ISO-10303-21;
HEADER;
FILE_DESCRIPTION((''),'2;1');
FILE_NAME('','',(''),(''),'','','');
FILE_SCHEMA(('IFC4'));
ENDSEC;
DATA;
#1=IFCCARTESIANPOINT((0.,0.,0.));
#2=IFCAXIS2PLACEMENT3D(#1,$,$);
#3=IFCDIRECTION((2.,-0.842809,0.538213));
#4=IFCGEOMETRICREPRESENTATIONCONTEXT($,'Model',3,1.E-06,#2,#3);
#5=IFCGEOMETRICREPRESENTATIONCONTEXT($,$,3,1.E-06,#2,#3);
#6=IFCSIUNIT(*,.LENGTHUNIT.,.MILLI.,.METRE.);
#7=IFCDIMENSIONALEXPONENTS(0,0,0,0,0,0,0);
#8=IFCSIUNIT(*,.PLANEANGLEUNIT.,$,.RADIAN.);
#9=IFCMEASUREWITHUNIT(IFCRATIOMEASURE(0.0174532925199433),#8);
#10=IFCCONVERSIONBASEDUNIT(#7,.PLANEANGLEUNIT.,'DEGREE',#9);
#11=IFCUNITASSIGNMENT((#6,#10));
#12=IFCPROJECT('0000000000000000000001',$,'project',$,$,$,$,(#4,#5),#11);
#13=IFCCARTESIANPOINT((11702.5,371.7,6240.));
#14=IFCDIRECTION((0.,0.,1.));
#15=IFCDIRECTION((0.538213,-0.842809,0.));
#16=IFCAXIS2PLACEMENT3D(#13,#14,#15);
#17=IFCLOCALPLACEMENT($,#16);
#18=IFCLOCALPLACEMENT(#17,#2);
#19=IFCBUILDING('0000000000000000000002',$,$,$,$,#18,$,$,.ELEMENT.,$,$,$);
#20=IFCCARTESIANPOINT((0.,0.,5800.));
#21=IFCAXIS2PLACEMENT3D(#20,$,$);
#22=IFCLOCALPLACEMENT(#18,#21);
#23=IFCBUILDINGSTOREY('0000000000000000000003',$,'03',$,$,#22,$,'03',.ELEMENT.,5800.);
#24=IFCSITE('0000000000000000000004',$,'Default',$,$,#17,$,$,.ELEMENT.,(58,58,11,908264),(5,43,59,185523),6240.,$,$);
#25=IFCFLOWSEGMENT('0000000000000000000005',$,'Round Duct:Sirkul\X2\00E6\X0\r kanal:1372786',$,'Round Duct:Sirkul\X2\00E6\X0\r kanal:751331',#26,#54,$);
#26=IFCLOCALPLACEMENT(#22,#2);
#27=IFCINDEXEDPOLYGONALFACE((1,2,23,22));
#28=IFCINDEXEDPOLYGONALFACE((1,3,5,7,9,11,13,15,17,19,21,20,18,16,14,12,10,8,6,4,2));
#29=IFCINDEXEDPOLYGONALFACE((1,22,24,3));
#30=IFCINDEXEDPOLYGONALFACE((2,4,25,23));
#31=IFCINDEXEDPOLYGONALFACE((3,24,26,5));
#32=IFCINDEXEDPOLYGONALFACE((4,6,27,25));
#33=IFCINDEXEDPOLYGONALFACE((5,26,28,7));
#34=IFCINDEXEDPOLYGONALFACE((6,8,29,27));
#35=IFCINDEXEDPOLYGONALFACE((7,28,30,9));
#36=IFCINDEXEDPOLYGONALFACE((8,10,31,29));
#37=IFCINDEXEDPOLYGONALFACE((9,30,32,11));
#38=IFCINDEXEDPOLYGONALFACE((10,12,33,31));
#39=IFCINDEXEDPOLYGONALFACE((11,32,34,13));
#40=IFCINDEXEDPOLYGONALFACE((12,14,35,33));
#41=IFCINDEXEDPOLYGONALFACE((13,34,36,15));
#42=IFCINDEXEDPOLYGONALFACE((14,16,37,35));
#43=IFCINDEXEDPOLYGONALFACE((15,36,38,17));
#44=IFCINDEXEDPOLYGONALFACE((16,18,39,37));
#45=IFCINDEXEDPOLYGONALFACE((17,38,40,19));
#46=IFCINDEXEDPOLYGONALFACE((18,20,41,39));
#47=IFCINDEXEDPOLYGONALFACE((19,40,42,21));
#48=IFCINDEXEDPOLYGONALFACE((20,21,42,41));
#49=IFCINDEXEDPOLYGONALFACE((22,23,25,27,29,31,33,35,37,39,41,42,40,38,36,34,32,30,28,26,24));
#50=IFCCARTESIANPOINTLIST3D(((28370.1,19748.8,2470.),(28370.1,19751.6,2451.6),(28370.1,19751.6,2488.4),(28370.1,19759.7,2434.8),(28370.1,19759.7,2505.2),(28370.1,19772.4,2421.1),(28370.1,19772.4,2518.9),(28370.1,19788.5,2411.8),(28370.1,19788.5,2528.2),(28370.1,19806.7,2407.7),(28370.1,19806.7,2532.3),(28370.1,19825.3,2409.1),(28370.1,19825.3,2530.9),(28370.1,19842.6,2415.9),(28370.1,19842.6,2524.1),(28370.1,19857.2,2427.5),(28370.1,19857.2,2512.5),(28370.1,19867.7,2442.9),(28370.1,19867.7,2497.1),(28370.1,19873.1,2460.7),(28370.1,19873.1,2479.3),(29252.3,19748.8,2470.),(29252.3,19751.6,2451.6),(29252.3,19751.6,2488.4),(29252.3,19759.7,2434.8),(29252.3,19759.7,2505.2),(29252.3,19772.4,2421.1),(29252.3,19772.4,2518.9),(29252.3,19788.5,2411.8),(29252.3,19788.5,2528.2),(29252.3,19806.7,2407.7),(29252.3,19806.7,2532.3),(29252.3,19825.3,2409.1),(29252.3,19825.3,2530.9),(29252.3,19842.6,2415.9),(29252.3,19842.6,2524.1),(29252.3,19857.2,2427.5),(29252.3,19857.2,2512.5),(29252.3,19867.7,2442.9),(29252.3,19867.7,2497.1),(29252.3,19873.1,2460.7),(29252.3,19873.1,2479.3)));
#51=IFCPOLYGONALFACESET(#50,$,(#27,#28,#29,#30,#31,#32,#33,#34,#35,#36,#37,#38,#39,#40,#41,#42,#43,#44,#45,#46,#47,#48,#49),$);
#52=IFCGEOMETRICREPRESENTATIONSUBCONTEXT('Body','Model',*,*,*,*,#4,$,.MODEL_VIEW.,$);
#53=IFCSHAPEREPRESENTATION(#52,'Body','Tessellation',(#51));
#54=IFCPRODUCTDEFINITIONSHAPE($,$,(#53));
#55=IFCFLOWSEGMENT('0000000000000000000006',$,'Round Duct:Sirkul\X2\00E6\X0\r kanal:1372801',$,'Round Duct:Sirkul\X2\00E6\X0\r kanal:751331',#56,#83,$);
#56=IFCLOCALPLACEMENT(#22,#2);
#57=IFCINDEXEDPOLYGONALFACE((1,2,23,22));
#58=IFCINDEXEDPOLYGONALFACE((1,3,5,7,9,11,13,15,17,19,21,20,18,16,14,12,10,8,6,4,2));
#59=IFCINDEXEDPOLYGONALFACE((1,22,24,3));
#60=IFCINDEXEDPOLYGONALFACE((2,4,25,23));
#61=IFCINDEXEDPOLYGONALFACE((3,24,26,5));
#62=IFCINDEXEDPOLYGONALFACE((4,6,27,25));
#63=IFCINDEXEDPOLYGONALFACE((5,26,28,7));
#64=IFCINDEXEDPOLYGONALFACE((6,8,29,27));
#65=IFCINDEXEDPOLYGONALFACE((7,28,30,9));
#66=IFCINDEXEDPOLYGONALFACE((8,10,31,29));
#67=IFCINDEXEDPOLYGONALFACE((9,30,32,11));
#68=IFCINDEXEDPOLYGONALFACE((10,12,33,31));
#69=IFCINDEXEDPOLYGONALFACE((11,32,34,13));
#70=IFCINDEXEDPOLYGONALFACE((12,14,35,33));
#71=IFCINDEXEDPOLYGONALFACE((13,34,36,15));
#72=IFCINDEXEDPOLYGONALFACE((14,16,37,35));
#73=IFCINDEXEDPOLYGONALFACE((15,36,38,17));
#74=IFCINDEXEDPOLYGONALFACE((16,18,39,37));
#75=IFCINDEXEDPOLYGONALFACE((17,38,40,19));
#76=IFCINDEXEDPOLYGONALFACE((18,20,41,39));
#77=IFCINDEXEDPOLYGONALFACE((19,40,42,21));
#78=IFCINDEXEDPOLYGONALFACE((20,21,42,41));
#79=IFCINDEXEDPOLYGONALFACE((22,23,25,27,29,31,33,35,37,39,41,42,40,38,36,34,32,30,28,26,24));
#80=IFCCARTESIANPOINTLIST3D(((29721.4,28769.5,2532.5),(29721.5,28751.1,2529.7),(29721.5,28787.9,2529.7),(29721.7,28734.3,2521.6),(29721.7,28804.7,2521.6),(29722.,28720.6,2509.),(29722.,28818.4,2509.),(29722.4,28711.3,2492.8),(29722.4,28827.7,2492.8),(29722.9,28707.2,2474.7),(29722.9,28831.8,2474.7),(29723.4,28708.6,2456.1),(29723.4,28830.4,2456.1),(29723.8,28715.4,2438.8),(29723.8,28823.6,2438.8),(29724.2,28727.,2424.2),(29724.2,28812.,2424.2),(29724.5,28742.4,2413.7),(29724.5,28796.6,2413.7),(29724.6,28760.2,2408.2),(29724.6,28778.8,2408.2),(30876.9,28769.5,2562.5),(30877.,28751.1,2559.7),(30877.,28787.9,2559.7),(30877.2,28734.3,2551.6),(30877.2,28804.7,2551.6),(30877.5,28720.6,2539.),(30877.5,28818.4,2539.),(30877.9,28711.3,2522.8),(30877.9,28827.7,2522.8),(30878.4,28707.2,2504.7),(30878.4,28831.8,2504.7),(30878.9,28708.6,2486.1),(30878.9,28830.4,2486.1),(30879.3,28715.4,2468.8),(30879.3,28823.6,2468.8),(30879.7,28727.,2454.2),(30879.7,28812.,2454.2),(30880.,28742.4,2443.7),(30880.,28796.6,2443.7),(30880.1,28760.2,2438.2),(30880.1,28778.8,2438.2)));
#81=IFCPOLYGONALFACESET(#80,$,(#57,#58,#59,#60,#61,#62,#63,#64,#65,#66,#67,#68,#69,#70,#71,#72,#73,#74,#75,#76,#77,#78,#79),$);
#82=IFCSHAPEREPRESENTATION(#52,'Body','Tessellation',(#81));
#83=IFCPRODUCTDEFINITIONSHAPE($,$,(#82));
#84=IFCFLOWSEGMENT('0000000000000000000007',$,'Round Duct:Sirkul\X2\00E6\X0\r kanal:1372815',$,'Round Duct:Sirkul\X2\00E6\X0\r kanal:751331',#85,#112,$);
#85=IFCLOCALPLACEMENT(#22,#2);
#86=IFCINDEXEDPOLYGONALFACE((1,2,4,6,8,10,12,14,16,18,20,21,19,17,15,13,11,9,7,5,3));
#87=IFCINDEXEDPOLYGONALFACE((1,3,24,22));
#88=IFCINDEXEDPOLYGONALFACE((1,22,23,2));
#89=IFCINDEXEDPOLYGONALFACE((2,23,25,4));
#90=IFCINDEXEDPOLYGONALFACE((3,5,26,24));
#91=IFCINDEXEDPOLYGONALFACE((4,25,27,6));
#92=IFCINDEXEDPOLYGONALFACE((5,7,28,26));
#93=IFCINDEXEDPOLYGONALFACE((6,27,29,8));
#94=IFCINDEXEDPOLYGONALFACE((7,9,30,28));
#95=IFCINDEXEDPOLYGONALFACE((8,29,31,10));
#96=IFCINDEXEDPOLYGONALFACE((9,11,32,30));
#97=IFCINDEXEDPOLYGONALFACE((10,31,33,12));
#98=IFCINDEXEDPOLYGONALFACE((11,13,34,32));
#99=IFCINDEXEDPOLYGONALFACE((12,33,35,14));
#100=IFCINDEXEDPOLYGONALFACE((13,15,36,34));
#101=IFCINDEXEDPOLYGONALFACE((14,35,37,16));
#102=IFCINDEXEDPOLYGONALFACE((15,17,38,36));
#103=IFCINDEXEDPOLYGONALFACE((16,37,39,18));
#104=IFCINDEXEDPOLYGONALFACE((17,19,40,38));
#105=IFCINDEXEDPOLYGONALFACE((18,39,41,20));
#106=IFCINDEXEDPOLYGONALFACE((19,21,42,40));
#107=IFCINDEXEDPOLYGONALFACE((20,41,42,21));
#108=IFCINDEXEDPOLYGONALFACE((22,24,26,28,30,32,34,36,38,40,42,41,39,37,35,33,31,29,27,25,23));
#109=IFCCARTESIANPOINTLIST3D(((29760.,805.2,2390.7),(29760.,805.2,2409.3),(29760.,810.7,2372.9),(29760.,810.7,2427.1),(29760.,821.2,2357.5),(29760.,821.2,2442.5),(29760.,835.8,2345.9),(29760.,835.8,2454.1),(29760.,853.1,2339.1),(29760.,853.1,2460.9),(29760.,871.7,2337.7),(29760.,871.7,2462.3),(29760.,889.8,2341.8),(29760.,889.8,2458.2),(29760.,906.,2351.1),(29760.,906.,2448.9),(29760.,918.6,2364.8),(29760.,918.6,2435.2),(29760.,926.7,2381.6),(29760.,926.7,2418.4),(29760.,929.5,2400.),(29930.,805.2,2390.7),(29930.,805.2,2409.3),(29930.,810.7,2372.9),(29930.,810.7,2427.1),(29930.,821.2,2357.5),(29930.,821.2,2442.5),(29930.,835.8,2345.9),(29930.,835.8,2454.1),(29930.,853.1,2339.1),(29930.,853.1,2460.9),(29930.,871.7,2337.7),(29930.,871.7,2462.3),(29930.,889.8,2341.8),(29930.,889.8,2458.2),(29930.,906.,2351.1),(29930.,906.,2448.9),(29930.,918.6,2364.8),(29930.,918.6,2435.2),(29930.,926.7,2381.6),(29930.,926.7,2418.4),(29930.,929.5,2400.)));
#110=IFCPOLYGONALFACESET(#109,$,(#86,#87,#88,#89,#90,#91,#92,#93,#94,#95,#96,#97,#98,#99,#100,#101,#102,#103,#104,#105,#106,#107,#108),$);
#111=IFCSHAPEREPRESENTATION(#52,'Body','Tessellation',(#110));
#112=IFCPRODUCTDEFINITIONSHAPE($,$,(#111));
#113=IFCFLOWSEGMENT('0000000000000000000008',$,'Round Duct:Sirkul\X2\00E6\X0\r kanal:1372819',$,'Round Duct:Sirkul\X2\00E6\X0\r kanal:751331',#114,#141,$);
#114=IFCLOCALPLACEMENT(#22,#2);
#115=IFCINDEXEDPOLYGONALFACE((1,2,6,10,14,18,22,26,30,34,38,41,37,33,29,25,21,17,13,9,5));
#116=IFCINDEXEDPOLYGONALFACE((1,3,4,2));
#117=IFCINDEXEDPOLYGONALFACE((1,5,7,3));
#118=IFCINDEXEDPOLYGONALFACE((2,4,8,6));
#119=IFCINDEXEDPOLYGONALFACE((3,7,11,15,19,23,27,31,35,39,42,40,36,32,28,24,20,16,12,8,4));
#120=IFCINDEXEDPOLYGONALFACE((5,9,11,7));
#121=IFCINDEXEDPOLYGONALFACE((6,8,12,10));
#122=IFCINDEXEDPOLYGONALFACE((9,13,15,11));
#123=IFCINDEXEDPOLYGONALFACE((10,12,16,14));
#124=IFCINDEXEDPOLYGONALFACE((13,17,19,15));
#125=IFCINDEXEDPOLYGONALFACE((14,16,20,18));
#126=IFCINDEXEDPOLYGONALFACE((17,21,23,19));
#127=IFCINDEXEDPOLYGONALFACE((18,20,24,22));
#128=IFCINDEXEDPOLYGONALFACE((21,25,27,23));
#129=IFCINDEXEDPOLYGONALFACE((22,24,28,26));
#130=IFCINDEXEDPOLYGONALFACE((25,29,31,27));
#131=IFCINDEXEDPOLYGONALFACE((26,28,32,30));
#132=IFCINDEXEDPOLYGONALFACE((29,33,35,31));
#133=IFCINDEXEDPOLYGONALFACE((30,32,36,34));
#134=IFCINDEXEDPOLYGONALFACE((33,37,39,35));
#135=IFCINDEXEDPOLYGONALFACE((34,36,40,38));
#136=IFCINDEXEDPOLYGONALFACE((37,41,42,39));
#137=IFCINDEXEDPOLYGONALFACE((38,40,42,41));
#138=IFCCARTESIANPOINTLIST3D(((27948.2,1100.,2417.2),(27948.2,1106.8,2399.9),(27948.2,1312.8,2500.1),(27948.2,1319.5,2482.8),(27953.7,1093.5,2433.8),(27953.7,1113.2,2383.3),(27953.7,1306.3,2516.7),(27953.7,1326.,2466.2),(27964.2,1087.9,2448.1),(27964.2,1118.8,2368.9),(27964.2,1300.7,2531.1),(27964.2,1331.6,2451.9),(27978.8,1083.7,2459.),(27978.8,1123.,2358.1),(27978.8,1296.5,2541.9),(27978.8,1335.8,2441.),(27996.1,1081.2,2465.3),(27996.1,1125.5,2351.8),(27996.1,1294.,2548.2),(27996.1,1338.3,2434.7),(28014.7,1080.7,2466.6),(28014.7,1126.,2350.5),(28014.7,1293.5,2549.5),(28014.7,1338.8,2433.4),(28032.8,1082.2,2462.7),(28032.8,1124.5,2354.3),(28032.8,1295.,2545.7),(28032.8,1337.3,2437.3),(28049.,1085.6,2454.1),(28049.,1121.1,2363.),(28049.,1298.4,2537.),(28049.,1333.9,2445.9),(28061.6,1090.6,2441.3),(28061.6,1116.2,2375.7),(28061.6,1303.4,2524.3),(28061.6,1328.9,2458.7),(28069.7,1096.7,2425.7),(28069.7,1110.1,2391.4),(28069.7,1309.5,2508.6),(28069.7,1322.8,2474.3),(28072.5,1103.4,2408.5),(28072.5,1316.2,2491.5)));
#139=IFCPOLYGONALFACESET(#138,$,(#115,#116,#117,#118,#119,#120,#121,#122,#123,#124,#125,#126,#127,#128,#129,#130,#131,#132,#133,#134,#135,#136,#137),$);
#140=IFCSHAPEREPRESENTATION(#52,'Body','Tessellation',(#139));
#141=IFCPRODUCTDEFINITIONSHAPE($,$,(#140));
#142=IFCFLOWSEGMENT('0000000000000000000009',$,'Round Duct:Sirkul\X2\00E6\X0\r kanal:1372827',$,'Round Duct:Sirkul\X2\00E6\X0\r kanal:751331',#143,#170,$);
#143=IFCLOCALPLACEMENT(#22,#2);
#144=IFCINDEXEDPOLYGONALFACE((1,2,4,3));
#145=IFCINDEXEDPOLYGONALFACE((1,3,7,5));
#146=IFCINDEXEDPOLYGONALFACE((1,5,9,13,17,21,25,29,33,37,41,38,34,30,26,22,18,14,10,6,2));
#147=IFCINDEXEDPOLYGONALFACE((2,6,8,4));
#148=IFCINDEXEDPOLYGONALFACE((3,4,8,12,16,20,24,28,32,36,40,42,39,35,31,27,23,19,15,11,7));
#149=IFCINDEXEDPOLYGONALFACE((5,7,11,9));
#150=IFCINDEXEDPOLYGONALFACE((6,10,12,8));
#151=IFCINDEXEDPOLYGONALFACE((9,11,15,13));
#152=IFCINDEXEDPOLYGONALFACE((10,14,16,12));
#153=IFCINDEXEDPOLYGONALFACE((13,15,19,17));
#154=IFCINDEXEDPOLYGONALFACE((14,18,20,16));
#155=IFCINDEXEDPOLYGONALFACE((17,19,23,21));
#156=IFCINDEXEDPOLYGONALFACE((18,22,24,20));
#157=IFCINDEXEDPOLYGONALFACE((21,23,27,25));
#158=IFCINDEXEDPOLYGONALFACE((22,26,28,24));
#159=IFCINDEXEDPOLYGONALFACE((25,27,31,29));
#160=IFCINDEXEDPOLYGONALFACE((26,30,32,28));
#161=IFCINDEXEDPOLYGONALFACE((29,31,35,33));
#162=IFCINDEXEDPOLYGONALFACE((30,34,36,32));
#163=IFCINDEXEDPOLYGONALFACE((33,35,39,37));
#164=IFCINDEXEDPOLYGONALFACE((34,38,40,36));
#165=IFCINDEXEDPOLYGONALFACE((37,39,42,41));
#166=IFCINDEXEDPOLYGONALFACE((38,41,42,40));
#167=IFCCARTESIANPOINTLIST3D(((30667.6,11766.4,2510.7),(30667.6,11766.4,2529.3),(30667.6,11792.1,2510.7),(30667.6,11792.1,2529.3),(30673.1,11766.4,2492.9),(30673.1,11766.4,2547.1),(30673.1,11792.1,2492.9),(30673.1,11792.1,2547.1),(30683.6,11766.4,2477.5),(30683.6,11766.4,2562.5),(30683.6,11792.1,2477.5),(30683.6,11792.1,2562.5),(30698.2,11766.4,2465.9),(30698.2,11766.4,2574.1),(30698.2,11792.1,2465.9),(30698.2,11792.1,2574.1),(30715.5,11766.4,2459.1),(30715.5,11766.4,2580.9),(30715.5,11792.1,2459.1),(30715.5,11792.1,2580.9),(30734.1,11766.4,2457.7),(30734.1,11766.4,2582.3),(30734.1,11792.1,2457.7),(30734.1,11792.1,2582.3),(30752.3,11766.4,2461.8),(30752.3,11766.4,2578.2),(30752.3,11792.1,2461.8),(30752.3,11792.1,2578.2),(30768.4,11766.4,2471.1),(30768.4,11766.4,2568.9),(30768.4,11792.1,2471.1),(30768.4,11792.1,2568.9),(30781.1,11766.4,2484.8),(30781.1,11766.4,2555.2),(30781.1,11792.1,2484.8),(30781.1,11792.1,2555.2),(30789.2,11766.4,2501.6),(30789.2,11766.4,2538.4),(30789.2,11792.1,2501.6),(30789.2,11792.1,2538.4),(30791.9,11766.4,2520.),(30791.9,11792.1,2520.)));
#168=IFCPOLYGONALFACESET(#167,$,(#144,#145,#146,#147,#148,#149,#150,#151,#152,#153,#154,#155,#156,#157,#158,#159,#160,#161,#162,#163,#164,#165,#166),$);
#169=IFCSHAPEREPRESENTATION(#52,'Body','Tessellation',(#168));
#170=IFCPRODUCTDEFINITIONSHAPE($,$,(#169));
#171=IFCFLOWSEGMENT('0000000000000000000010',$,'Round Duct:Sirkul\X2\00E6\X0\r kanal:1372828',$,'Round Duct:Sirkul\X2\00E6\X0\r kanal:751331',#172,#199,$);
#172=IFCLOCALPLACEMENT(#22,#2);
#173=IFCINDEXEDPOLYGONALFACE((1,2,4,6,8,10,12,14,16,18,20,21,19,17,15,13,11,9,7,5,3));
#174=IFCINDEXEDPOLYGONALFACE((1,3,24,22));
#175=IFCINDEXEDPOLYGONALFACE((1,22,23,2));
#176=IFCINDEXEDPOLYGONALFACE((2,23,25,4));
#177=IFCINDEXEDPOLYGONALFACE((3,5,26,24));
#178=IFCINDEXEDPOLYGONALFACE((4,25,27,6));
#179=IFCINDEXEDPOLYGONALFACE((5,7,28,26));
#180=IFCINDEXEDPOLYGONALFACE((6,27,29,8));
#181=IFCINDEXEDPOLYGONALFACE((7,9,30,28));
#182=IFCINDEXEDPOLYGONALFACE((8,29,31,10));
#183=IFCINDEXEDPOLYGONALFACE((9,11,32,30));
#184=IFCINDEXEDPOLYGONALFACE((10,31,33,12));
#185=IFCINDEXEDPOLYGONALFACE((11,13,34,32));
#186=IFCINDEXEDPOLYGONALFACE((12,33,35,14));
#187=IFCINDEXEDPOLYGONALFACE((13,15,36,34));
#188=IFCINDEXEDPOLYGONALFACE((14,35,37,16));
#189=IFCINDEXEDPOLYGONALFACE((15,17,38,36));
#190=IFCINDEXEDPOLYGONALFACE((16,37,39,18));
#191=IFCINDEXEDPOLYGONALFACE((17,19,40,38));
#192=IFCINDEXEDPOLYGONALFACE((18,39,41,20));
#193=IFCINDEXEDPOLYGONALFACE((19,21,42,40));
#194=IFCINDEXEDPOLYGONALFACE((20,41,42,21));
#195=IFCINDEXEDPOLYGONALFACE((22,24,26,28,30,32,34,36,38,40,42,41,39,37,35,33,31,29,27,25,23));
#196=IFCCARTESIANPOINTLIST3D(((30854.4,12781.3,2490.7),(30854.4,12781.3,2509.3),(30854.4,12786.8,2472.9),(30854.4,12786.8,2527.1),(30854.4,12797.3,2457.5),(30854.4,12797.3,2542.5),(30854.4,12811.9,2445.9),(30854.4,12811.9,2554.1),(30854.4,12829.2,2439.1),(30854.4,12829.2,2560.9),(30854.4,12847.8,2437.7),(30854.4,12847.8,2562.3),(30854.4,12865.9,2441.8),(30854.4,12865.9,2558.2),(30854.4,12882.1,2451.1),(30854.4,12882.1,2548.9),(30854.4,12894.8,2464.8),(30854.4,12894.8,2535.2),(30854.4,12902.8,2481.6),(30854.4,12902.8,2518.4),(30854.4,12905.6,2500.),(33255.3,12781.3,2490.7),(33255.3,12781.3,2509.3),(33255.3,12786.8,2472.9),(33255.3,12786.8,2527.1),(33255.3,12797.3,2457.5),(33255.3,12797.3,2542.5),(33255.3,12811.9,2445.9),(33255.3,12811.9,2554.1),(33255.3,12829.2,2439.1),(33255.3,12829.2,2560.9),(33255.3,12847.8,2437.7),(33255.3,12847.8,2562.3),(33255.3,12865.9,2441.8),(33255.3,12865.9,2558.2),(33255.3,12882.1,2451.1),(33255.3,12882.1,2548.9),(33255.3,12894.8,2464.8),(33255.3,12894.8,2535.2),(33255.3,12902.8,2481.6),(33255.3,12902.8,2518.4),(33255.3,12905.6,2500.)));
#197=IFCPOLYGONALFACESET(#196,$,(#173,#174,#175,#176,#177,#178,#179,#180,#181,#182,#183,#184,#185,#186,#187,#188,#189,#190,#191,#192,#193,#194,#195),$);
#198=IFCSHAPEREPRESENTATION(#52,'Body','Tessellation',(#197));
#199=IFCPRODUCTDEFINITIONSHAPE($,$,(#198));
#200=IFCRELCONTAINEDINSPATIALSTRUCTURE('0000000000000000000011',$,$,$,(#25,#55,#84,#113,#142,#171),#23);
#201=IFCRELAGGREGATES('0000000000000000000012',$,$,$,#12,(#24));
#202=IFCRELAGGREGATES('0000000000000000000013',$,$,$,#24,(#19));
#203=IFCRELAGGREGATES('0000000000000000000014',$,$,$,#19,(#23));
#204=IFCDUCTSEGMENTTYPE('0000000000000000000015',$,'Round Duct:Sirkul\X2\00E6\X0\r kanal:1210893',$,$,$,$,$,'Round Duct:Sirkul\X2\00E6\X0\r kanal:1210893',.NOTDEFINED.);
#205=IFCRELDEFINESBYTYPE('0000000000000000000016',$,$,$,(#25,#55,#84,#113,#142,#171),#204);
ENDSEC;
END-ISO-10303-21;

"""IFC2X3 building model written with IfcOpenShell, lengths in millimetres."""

from ifc_helpers import new_model, entity, si_unit, converted_unit, direction, frame, frame_2d, origin, origin_2d_with_axis, place, context, subcontext, project, spatial, circle, extrude, type_object, element, save


model = new_model("IFC2X3")

# Units and contexts
model_context = context("Model", 3, precision=1e-06, world=origin(), true_north=direction((2.0, -0.842809, 0.538213)))
context_of_model = context(None, 3, precision=1e-06, world=origin(), true_north=direction((2.0, -0.842809, 0.538213)))
body_context = subcontext(model_context, "Body", "Model", "MODEL_VIEW")
ifc_project = project(units=[si_unit("LENGTHUNIT", "METRE", prefix="MILLI"), converted_unit("PLANEANGLEUNIT", "DEGREE", entity("IfcRatioMeasure", 0.0174532925199433), si_unit("PLANEANGLEUNIT", "RADIAN"), dimensions=[0, 0, 0, 0, 0, 0, 0])], contexts=[model_context, context_of_model])

# Site, building, storey
site_placement = place(None, frame((11702.5, 371.7, 6240.0), z_axis=(0.0, 0.0, 1.0), x_axis=(0.538213, -0.842809, 0.0)))
site = spatial("IfcSite", under=ifc_project, at=site_placement, Name="Default", CompositionType="ELEMENT", RefLatitude=(58, 58, 11, 908264), RefLongitude=(5, 43, 59, 185523), RefElevation=6240.0)
building_placement = place(site_placement, origin())
building = spatial("IfcBuilding", under=site, at=building_placement, CompositionType="ELEMENT")
storey_placement = place(building_placement, frame((0.0, 0.0, 5800.0)))
storey = spatial("IfcBuildingStorey", under=building, at=storey_placement, Name="03", LongName="03", CompositionType="ELEMENT", Elevation=5800.0)

# Flow segments
duct_segment_type_1 = type_object("IfcDuctSegmentType", Name="Round Duct:Sirkulær kanal:1210893", ElementType="Round Duct:Sirkulær kanal:1210893", PredefinedType="NOTDEFINED")
flow_segment_1_placement = place(storey_placement, origin())
element("IfcFlowSegment", 1, at=flow_segment_1_placement, inside=storey, type_object=duct_segment_type_1, Name="Round Duct:Sirkulær kanal:1372786", ObjectType="Round Duct:Sirkulær kanal:751331", context=body_context, shape_type="SweptSolid", body=[
    extrude(circle(Radius=62.5, at=frame_2d((0.0, 0.0), x_axis=(1.0, 0.0))), frame((28370.1, 19811.3, 2470.0), z_axis=(1.0, 0.0, 0.0), x_axis=(0.0, -1.0, 0.0)), (0.0, 0.0, 1.0), 882.2),
])
flow_segment_2_placement = place(storey_placement, origin())
element("IfcFlowSegment", 2, at=flow_segment_2_placement, inside=storey, type_object=duct_segment_type_1, Name="Round Duct:Sirkulær kanal:1372801", ObjectType="Round Duct:Sirkulær kanal:751331", context=body_context, shape_type="SweptSolid", body=[
    extrude(circle(Radius=62.5, at=frame_2d((0.0, 0.0), x_axis=(1.0, 0.0))), frame((29723.0, 28769.5, 2470.0), z_axis=(0.999663, 0.0, 0.025955), x_axis=(-0.025955, 0.0, 0.999663)), (0.0, 0.0, 1.0), 1155.9),
])
flow_segment_3_placement = place(storey_placement, origin())
element("IfcFlowSegment", 3, at=flow_segment_3_placement, inside=storey, type_object=duct_segment_type_1, Name="Round Duct:Sirkulær kanal:1372815", ObjectType="Round Duct:Sirkulær kanal:751331", context=body_context, shape_type="SweptSolid", body=[
    extrude(circle(Radius=62.5, at=frame_2d((0.0, 0.0), x_axis=(1.0, 0.0))), frame((29760.0, 867.0, 2400.0), z_axis=(1.0, 0.0, 0.0), x_axis=(0.0, 1.0, 0.0)), (0.0, 0.0, 1.0), 170.0),
])
flow_segment_4_placement = place(storey_placement, origin())
element("IfcFlowSegment", 4, at=flow_segment_4_placement, inside=storey, type_object=duct_segment_type_1, Name="Round Duct:Sirkulær kanal:1372819", ObjectType="Round Duct:Sirkulær kanal:751331", context=body_context, shape_type="SweptSolid", body=[
    extrude(circle(Radius=62.5, at=origin_2d_with_axis()), frame((28010.0, 1103.4, 2408.5), z_axis=(0.0, 0.931734, 0.363142), x_axis=(1.0, 0.0, 0.0)), (0.0, 0.0, 1.0), 228.4),
])
flow_segment_5_placement = place(storey_placement, origin())
element("IfcFlowSegment", 5, at=flow_segment_5_placement, inside=storey, type_object=duct_segment_type_1, Name="Round Duct:Sirkulær kanal:1372827", ObjectType="Round Duct:Sirkulær kanal:751331", context=body_context, shape_type="SweptSolid", body=[
    extrude(circle(Radius=62.5, at=origin_2d_with_axis()), frame((30729.4, 11766.4, 2520.0), z_axis=(0.0, 1.0, 0.0), x_axis=(1.0, 0.0, 0.0)), (0.0, 0.0, 1.0), 25.7),
])
flow_segment_6_placement = place(storey_placement, origin())
element("IfcFlowSegment", 6, at=flow_segment_6_placement, inside=storey, type_object=duct_segment_type_1, Name="Round Duct:Sirkulær kanal:1372828", ObjectType="Round Duct:Sirkulær kanal:751331", context=body_context, shape_type="SweptSolid", body=[
    extrude(circle(Radius=62.5, at=frame_2d((0.0, 0.0), x_axis=(1.0, 0.0))), frame((30854.4, 12843.1, 2500.0), z_axis=(1.0, 0.0, 0.0), x_axis=(0.0, 1.0, 0.0)), (0.0, 0.0, 1.0), 2400.8),
])

save(model, "model.ifc")
